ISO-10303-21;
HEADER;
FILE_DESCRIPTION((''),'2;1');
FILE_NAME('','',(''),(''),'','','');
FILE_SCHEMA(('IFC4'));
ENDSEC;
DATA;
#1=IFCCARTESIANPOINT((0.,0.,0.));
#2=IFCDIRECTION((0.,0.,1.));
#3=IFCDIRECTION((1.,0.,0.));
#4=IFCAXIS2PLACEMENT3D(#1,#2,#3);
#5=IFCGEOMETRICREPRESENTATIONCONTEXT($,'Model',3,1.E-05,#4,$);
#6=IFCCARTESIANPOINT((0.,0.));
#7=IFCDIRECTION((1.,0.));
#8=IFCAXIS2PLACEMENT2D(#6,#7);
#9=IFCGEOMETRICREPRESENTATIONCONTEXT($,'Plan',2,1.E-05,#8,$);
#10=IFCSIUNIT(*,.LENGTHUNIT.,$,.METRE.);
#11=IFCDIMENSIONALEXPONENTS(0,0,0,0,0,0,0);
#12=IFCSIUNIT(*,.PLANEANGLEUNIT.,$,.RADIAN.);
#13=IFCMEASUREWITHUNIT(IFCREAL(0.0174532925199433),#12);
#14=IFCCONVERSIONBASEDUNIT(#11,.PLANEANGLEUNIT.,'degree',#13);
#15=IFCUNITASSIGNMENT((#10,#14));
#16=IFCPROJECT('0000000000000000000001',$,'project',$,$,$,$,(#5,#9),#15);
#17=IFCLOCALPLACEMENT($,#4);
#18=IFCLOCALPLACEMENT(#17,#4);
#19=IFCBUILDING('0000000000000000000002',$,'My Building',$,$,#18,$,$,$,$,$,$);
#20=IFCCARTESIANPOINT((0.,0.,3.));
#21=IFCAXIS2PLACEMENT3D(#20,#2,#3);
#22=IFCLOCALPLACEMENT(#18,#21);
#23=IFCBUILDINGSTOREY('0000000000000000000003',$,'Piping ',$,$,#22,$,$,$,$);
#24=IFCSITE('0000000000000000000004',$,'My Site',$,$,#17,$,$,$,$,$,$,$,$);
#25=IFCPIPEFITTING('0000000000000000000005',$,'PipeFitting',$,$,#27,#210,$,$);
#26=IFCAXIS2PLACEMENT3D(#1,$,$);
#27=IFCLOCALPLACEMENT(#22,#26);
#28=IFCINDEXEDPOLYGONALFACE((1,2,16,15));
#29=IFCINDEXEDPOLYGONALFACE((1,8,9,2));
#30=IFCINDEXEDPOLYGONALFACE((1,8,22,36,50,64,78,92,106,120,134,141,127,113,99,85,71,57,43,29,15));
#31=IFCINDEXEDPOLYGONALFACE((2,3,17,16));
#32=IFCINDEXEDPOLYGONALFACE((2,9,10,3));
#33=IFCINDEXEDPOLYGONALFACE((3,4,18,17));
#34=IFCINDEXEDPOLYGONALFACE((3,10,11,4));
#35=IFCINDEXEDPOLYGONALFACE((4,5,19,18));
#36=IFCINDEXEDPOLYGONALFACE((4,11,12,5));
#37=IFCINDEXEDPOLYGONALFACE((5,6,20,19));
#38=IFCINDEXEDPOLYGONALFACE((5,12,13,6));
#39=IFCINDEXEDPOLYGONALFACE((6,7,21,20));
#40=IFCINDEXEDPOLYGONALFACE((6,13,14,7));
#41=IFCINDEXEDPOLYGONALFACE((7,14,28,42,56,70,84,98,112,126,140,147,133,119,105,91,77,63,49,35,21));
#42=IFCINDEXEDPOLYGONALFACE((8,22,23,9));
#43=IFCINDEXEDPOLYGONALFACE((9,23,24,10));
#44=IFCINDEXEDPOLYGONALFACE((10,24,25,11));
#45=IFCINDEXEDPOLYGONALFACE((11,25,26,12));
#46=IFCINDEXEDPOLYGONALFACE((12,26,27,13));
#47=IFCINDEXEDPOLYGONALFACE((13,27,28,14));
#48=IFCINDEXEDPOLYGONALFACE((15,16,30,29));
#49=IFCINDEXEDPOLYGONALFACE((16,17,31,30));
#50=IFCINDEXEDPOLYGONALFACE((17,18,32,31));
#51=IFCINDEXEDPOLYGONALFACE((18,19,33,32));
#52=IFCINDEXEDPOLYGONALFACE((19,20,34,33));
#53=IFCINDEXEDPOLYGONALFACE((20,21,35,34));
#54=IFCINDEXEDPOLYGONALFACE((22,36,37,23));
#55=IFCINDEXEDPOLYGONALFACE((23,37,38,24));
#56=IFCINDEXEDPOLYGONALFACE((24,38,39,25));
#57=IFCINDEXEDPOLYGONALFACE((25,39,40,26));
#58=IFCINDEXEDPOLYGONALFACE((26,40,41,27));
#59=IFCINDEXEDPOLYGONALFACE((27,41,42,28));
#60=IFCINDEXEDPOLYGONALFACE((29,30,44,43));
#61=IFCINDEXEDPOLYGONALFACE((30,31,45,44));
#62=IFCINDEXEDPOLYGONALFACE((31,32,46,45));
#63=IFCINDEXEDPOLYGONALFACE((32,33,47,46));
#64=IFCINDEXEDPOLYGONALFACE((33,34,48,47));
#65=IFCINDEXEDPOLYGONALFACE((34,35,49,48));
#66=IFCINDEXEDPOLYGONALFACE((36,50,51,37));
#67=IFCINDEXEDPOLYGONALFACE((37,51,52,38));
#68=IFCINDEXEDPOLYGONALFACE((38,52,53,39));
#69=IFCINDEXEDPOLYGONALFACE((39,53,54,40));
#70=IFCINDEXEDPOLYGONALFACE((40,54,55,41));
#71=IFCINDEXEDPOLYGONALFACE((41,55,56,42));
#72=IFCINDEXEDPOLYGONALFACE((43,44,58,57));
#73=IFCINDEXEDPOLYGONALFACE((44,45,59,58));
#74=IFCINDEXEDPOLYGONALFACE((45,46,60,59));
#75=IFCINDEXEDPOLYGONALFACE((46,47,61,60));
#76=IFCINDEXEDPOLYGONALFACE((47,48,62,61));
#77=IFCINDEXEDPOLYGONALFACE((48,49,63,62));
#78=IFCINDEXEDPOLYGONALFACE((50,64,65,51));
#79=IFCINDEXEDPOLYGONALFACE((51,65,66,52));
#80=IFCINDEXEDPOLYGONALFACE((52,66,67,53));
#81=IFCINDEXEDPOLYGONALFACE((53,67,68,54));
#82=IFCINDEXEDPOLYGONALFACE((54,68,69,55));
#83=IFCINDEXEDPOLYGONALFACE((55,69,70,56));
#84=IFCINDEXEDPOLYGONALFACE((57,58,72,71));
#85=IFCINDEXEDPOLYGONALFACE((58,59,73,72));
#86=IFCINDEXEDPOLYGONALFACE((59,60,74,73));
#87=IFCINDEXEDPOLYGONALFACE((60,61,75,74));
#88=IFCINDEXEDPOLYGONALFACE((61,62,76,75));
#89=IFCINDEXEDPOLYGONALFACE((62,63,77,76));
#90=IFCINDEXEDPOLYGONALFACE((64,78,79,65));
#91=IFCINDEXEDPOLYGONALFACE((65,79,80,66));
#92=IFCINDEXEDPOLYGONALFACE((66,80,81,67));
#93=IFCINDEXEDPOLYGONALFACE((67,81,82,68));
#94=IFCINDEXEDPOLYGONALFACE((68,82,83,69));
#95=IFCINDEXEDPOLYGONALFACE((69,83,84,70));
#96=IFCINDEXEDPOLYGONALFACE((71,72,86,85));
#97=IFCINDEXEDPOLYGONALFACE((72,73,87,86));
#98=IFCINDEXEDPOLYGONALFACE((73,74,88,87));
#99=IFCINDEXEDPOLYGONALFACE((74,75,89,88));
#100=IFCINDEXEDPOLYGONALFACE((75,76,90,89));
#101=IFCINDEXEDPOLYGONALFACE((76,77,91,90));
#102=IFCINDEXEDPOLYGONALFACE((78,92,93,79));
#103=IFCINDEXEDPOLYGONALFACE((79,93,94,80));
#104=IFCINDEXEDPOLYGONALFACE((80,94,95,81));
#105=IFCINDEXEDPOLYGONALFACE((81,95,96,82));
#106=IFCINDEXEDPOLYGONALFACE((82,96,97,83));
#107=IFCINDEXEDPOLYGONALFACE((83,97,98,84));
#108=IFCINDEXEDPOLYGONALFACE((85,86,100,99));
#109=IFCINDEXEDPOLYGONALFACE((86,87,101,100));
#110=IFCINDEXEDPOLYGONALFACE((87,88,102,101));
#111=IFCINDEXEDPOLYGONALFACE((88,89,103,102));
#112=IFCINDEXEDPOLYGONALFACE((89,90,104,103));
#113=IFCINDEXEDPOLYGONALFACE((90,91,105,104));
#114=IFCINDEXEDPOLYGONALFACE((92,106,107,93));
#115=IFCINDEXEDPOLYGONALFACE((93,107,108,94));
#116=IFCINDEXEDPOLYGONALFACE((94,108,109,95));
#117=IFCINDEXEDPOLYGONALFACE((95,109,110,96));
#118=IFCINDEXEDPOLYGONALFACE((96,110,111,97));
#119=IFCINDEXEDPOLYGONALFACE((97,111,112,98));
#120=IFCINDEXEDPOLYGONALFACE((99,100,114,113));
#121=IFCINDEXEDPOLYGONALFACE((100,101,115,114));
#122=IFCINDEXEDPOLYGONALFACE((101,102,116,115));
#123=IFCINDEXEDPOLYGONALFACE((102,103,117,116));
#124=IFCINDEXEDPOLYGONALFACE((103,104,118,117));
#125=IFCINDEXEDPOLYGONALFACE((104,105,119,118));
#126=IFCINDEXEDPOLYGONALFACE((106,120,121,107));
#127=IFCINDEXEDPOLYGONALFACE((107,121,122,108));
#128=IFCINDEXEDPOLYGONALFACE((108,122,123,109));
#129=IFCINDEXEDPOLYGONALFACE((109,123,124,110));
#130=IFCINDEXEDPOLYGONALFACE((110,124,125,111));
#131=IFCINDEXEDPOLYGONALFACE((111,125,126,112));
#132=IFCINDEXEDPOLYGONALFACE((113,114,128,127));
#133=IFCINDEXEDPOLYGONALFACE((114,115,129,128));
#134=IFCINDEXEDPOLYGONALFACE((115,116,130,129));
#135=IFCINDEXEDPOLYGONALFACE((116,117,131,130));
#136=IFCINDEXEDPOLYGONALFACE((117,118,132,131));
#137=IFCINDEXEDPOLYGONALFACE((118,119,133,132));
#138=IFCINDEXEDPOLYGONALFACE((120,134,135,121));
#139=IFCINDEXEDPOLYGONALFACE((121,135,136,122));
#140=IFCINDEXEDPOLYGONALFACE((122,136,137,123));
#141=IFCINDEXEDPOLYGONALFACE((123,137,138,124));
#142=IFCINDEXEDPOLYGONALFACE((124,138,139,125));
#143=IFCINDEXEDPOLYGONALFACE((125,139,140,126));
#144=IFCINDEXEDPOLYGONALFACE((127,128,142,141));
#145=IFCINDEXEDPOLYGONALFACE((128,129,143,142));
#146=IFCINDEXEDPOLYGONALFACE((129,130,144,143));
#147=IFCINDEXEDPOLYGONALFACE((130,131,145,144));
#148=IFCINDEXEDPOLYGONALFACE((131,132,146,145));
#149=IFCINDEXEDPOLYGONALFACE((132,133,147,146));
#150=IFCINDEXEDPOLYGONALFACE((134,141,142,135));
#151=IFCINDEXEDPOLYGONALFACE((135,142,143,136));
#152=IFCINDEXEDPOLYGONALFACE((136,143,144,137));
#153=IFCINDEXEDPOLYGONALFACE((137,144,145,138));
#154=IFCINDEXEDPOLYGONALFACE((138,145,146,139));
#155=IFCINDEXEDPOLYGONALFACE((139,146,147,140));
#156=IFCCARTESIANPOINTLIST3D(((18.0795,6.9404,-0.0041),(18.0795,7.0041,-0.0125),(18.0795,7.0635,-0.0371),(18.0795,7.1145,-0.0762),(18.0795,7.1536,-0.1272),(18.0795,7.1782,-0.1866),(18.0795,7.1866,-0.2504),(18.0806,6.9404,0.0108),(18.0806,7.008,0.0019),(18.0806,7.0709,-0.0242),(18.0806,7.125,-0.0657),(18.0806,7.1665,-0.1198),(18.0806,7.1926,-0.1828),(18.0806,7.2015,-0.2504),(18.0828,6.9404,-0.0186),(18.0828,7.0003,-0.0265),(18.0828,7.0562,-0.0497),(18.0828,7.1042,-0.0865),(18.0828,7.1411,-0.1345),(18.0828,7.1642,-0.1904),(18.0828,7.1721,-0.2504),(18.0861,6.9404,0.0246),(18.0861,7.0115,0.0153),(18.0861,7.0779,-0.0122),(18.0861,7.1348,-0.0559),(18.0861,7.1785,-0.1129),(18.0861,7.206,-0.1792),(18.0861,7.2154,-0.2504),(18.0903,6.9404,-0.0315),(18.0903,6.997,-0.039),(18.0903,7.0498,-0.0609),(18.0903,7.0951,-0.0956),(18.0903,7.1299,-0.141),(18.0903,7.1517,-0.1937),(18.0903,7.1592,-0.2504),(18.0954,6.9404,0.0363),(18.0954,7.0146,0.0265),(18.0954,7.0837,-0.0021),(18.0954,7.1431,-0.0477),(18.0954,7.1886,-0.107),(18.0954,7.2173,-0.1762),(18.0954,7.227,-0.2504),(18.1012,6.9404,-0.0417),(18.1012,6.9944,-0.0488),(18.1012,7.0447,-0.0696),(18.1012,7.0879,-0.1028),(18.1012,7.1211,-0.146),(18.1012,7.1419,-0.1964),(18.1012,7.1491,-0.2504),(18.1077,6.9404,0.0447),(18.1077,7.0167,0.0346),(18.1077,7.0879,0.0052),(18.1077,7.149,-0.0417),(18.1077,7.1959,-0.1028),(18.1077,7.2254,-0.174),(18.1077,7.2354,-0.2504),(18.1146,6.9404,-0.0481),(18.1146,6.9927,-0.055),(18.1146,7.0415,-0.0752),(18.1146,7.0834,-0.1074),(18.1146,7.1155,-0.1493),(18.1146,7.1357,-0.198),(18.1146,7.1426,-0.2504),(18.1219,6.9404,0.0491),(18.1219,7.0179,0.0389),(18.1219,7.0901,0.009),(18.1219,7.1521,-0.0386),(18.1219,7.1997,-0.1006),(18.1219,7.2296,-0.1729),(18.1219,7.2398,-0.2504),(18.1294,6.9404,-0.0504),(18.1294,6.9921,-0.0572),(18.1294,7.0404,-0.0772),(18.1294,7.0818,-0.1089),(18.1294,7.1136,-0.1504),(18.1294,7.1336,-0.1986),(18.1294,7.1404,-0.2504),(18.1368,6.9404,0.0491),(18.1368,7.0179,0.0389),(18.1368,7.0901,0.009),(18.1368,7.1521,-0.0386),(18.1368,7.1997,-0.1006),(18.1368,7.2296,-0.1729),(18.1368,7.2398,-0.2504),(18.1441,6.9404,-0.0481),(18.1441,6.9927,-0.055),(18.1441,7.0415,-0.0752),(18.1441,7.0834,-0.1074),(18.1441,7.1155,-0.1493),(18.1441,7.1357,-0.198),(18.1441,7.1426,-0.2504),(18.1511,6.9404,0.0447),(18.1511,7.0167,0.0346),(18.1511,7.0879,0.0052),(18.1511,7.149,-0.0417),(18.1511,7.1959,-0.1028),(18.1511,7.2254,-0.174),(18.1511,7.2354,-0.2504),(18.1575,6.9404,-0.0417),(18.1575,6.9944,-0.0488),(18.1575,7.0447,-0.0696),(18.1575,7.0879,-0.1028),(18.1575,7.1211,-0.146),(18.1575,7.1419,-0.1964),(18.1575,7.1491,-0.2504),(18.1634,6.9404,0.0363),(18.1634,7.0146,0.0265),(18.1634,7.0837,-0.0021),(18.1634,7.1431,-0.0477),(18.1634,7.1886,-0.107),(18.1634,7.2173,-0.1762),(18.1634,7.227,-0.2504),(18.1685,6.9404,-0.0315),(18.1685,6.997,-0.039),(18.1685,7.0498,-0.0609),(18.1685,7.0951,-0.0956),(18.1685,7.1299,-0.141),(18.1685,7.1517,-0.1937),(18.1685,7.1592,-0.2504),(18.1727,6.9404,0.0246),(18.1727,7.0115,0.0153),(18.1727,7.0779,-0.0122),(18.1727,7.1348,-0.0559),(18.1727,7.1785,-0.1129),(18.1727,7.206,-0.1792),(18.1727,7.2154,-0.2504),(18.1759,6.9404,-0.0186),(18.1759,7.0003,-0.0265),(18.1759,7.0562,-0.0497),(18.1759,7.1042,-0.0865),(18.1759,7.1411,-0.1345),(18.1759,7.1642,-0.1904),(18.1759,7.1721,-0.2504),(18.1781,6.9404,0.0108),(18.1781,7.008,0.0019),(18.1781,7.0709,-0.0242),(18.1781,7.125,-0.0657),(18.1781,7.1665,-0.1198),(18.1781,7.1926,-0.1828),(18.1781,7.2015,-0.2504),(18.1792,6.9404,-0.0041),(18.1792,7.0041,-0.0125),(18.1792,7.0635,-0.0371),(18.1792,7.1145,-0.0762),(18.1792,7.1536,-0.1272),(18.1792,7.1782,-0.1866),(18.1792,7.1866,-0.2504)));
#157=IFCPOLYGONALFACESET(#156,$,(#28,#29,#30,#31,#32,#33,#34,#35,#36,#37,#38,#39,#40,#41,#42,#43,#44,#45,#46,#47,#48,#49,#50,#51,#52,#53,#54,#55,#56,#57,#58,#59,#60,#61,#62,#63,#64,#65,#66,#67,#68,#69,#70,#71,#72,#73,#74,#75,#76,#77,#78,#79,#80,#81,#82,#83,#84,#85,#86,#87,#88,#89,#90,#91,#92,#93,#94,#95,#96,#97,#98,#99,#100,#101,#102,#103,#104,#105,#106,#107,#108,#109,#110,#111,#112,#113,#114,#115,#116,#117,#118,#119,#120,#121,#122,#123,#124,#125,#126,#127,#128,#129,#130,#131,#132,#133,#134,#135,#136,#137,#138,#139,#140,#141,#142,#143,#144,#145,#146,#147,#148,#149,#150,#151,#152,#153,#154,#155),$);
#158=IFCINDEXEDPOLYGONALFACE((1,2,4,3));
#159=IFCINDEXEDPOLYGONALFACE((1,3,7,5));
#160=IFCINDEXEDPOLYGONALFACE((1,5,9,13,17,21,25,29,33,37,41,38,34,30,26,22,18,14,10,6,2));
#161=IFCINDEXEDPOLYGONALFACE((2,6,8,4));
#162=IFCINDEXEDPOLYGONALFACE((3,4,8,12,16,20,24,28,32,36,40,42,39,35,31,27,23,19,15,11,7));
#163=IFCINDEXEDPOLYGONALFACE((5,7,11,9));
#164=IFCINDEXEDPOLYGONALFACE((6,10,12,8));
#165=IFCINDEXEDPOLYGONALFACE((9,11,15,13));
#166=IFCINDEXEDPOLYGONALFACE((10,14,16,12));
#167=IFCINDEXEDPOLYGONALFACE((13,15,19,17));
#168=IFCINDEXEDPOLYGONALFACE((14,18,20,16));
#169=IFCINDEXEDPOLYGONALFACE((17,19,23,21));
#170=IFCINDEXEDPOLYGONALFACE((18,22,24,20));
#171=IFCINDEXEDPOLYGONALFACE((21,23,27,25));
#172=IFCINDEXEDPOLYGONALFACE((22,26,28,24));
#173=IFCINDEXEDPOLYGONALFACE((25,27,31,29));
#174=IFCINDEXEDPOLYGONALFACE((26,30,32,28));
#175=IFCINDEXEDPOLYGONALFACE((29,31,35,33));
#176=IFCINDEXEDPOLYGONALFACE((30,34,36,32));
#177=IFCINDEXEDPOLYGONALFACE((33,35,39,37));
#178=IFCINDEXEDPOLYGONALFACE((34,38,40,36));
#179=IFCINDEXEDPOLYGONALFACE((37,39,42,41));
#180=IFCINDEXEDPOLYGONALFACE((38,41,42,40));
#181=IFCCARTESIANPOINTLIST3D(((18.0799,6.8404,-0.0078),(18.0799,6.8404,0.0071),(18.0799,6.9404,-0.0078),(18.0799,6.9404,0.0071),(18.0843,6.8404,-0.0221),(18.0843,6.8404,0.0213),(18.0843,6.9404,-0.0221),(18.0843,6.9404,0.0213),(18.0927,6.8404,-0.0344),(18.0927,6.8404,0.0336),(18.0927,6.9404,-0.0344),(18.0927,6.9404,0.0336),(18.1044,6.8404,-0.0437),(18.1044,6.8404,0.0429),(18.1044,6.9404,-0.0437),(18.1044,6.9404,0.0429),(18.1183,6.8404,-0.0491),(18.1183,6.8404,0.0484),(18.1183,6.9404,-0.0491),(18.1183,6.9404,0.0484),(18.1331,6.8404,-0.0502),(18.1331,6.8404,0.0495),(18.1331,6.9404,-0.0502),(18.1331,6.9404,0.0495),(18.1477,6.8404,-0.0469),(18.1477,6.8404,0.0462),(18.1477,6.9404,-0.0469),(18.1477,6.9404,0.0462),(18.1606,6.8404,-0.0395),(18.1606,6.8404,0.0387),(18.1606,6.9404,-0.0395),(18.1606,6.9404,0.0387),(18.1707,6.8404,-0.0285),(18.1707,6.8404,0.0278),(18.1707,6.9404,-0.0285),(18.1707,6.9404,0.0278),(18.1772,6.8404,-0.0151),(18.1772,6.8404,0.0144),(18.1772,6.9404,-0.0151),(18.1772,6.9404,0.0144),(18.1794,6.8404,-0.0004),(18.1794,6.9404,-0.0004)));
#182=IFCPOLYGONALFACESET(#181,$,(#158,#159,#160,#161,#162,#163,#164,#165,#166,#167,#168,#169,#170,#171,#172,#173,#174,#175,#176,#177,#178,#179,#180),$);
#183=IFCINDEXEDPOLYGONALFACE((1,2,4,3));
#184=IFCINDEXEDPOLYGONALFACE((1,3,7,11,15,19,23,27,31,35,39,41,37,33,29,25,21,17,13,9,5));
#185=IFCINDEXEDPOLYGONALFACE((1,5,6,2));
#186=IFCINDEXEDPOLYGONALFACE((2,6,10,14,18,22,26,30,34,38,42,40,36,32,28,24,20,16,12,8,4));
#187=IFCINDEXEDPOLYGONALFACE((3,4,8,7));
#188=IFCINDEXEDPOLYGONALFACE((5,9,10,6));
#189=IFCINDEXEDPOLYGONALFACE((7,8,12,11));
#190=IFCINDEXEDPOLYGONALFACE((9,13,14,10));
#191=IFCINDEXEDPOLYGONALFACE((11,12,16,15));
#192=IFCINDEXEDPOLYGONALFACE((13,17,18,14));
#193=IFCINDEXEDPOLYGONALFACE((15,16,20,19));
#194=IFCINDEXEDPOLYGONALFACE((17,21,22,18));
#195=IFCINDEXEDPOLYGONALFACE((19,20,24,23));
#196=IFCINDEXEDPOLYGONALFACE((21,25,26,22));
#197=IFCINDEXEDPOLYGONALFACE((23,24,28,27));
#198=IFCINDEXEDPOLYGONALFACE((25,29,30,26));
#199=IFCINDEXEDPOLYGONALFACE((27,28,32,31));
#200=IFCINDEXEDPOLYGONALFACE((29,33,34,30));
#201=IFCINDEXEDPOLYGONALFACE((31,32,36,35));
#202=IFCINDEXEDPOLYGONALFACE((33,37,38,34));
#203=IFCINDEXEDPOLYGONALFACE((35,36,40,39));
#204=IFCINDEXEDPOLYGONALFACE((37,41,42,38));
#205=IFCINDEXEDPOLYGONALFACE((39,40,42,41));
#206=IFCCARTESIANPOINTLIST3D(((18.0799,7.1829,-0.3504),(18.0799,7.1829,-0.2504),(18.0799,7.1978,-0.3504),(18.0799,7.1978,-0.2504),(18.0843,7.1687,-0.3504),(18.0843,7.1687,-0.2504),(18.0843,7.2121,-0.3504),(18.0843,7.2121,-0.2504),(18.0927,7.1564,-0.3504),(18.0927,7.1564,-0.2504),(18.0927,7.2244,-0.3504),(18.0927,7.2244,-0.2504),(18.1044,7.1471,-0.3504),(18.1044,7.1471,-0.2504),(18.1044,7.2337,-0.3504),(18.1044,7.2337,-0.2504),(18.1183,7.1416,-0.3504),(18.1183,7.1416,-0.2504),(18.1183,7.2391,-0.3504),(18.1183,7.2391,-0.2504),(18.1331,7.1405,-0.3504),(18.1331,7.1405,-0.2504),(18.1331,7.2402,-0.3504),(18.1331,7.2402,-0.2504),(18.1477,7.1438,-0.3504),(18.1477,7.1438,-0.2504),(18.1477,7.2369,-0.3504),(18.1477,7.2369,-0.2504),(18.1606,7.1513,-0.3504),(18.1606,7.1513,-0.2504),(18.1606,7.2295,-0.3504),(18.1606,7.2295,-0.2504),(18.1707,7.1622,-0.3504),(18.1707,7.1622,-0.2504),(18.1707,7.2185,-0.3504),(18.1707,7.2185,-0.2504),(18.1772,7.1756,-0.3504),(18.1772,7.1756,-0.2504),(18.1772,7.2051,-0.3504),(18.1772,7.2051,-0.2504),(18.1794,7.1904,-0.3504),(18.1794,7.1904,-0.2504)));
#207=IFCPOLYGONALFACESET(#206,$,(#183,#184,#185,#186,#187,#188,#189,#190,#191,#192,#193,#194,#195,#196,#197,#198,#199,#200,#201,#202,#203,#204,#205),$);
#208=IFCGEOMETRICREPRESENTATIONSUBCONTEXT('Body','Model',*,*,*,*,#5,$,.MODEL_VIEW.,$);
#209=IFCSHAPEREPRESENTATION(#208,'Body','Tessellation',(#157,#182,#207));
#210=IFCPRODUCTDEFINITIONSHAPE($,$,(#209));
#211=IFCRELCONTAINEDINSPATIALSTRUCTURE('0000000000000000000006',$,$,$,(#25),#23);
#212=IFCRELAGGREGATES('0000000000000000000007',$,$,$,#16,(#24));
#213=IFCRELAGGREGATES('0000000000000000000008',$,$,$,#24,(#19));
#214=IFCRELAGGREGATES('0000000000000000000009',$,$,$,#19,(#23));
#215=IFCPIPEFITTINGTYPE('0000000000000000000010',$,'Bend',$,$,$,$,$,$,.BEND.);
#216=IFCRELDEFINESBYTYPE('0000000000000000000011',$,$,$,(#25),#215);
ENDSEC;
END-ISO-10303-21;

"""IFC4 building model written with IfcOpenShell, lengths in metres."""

from ifc_helpers import new_model, entity, si_unit, converted_unit, frame, origin_with_axes, origin_2d_with_axis, place, context, subcontext, project, spatial, circle, extrude, source, transform, mapped, type_object, type_shapes, element, save


model = new_model("IFC4")

# Units and contexts
model_context = context("Model", 3, precision=1e-05, world=origin_with_axes())
plan_context = context("Plan", 2, precision=1e-05, world=origin_2d_with_axis())
body_context = subcontext(model_context, "Body", "Model", "MODEL_VIEW")
ifc_project = project(units=[si_unit("LENGTHUNIT", "METRE"), converted_unit("PLANEANGLEUNIT", "degree", entity("IfcReal", 0.0174532925199433), si_unit("PLANEANGLEUNIT", "RADIAN"), dimensions=[0, 0, 0, 0, 0, 0, 0])], contexts=[model_context, plan_context])

# Site, building, storey
site_placement = place(None, origin_with_axes())
site = spatial("IfcSite", under=ifc_project, at=site_placement, Name="My Site")
building_placement = place(site_placement, origin_with_axes())
building = spatial("IfcBuilding", under=site, at=building_placement, Name="My Building")
storey_placement = place(building_placement, frame((0.0, 0.0, 3.0), z_axis=(0.0, 0.0, 1.0), x_axis=(1.0, 0.0, 0.0)))
storey = spatial("IfcBuildingStorey", under=building, at=storey_placement, Name="Piping ")

# Pipe fitting
pipe_fitting_type = type_object("IfcPipeFittingType", Name="Bend", PredefinedType="BEND")
shared_shape = source(origin_with_axes(), body_context, "Body", "SolidModel", [
    entity("IfcSweptDiskSolid", entity("IfcIndexedPolyCurve", entity("IfcCartesianPointList3D", [[0.0, 0.0, -0.1], [0.0, -0.0732, -0.2768], [0.0, -0.25, -0.35]]), [entity("IfcArcIndex", [1, 2, 3])]), 0.05),
    extrude(circle(Radius=0.05), origin_with_axes(), (0.0, 0.0, -1.0), 0.1),
    extrude(circle(Radius=0.05), frame((0.0, -0.25, -0.35), z_axis=(0.0, -1.0, 0.0), x_axis=(1.0, 0.0, 0.0)), (0.0, 0.0, 1.0), 0.1),
])
type_shapes(pipe_fitting_type, [shared_shape])
for number, where, z_axis, x_axis, name in (
    (1, (18.1294, 6.8404, -0.0004), (0.0, -1.0, 0.0), (1.0, 0.0, 0.0), "PipeFitting"),
):
    element("IfcPipeFitting", number, at=place(storey_placement, frame(where, z_axis=z_axis, x_axis=x_axis)), inside=storey, type_object=pipe_fitting_type, Name=name, context=body_context, shape_type="MappedRepresentation", body=[
        mapped(shared_shape, transform((0.0, 0.0, 0.0), x_axis=(1.0, 0.0, 0.0), y_axis=(0.0, 1.0, 0.0), z_axis=(0.0, 0.0, 1.0), scale=1.0)),
    ])

save(model, "model.ifc")
